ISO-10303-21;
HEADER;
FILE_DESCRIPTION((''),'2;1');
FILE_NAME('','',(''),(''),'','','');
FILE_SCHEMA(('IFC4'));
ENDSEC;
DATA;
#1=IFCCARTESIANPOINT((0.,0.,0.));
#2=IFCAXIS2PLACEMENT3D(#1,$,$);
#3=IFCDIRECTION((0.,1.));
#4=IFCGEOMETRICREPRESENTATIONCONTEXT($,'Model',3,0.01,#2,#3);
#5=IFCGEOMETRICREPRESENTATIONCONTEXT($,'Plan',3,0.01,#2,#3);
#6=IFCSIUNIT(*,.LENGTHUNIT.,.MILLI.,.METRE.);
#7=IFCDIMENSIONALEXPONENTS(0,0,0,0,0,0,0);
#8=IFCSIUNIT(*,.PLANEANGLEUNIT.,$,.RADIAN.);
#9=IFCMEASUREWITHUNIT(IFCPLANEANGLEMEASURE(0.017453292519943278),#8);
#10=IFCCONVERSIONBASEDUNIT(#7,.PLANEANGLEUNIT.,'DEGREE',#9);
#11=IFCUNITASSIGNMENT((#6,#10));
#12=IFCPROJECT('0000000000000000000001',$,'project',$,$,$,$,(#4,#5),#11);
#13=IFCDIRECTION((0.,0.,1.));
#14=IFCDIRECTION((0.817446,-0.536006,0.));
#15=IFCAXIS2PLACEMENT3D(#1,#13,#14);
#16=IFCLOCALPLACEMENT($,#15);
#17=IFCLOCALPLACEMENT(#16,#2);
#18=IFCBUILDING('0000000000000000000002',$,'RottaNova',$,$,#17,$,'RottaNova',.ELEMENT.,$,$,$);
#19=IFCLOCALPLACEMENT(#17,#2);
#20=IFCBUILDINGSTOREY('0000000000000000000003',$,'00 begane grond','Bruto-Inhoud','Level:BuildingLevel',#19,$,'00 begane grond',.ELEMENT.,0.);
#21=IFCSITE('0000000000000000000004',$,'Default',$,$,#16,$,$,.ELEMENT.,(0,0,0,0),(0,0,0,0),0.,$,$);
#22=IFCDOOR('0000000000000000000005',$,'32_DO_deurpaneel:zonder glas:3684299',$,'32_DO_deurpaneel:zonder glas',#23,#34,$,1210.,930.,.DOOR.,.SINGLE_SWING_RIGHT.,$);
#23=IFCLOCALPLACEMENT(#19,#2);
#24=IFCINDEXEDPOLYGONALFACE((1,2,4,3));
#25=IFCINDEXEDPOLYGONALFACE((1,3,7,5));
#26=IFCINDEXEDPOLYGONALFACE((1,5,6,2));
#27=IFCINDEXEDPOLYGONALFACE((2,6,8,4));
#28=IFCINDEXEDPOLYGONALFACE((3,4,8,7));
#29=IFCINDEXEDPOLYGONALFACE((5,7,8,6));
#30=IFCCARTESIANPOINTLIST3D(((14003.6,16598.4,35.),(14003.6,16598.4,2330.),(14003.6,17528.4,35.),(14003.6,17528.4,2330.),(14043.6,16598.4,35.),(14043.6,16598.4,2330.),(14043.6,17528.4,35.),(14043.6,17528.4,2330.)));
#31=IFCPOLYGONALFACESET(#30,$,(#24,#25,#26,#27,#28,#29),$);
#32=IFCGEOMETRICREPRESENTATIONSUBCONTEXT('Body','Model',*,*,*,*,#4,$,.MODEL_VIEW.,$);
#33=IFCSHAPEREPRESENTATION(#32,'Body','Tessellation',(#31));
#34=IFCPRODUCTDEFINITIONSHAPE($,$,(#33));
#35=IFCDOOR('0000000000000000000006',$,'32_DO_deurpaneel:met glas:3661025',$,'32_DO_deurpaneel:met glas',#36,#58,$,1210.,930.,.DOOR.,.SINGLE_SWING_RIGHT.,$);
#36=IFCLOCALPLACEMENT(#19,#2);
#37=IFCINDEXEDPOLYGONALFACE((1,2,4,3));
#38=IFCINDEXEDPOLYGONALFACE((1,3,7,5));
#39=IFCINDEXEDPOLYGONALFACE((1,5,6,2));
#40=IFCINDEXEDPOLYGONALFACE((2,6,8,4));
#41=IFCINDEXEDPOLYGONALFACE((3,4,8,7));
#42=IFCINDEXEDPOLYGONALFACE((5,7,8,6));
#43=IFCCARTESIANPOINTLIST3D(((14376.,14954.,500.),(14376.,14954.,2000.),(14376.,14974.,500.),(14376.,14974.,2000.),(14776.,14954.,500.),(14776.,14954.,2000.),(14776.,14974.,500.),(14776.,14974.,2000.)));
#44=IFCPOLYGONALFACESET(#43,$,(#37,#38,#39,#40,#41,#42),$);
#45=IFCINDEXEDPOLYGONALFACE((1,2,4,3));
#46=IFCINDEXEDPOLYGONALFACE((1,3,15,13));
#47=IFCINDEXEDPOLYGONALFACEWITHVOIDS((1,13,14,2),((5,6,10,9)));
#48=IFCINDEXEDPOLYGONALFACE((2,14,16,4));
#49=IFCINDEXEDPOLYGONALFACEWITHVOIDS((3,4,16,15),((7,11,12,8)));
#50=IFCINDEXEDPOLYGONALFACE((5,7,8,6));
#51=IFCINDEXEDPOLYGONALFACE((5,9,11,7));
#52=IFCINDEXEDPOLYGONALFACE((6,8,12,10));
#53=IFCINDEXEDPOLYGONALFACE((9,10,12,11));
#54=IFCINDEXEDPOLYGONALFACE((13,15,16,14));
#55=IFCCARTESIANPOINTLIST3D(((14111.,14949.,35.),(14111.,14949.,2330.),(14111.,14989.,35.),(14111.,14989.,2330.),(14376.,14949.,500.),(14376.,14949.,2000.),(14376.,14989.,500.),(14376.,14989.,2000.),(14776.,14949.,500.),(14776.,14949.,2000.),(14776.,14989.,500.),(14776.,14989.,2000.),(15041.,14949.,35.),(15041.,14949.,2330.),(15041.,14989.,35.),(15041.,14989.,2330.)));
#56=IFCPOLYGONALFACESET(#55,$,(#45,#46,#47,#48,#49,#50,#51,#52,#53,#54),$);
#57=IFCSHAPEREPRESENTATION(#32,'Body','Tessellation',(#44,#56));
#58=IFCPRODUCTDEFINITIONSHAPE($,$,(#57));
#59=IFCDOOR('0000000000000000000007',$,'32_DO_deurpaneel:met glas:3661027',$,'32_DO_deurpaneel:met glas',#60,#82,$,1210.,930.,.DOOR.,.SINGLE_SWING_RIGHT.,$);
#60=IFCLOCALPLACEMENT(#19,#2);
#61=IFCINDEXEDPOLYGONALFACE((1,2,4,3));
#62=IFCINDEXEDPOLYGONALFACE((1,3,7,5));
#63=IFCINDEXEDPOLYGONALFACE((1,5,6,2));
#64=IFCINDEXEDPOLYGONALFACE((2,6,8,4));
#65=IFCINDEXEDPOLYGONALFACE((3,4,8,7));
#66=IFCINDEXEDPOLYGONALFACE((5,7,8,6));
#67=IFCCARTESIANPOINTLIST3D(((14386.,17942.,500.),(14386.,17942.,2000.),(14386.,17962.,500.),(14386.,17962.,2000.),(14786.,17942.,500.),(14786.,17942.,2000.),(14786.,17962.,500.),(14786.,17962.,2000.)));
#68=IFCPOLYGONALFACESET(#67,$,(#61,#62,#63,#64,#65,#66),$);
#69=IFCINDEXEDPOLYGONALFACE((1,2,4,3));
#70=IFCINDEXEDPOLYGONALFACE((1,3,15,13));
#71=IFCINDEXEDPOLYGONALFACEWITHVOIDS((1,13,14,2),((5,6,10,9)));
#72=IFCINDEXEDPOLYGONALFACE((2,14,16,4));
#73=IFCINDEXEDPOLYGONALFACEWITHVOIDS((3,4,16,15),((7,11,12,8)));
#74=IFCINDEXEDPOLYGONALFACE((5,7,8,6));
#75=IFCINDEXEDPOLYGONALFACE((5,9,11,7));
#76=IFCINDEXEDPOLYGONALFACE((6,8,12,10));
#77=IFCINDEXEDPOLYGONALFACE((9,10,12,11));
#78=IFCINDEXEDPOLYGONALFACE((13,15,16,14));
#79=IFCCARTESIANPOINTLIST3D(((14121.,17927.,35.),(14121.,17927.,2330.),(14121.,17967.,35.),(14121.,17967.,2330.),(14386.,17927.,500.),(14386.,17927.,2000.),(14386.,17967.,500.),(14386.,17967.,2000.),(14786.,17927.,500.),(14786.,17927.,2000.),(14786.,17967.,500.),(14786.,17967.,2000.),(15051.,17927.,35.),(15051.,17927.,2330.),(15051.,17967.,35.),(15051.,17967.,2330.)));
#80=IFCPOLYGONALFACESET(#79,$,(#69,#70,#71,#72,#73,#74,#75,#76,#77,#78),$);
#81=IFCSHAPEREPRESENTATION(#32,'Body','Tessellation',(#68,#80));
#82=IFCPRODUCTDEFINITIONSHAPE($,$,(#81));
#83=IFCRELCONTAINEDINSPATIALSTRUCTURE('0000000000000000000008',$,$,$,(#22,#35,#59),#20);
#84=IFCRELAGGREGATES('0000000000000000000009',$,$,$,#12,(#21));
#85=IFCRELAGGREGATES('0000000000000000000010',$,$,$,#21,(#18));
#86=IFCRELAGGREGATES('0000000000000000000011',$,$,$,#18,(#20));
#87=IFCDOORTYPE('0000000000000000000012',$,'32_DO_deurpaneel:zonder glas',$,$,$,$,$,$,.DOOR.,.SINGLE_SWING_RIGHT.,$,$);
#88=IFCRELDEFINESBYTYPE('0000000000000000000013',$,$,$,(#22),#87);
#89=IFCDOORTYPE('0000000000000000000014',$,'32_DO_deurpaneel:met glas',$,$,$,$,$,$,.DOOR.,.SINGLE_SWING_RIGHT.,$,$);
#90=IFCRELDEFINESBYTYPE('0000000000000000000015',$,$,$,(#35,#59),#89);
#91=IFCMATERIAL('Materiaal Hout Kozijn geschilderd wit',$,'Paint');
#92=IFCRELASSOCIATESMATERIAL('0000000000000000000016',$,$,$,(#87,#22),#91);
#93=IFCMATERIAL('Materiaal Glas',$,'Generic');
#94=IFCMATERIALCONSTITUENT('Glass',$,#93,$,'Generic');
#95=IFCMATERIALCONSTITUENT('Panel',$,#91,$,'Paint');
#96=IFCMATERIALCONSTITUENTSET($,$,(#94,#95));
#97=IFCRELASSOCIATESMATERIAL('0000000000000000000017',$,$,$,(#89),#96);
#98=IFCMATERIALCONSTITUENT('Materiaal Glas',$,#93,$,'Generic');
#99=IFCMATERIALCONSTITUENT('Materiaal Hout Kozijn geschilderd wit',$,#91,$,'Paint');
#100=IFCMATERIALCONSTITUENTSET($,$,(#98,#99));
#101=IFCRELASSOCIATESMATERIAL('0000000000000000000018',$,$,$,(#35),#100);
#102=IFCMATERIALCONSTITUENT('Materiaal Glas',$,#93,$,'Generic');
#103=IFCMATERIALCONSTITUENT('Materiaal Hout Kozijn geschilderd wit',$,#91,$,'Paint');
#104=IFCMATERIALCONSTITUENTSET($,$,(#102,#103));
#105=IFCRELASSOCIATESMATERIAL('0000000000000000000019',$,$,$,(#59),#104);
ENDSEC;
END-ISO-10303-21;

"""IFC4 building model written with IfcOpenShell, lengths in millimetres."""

from ifc_helpers import new_model, entity, si_unit, converted_unit, direction, frame, origin, place, context, subcontext, project, spatial, indexed_curve, outline, extrude, source, transform, mapped, material, constituent, constituent_set, type_object, type_shapes, element, save


model = new_model("IFC4")

# Units and contexts
model_context = context("Model", 3, precision=0.01, world=origin(), true_north=direction((0.0, 1.0)))
plan_context = context("Plan", 3, precision=0.01, world=origin(), true_north=direction((0.0, 1.0)))
body_context = subcontext(model_context, "Body", "Model", "MODEL_VIEW")
ifc_project = project(units=[si_unit("LENGTHUNIT", "METRE", prefix="MILLI"), converted_unit("PLANEANGLEUNIT", "DEGREE", entity("IfcPlaneAngleMeasure", 0.017453292519943278), si_unit("PLANEANGLEUNIT", "RADIAN"), dimensions=[0, 0, 0, 0, 0, 0, 0])], contexts=[model_context, plan_context])

# Site, building, storey
site_placement = place(None, frame((0.0, 0.0, 0.0), z_axis=(0.0, 0.0, 1.0), x_axis=(0.817446, -0.536006, 0.0)))
site = spatial("IfcSite", under=ifc_project, at=site_placement, Name="Default", CompositionType="ELEMENT", RefLatitude=(0, 0, 0, 0), RefLongitude=(0, 0, 0, 0), RefElevation=0.0)
building_placement = place(site_placement, origin())
building = spatial("IfcBuilding", under=site, at=building_placement, Name="RottaNova", LongName="RottaNova", CompositionType="ELEMENT")
storey_placement = place(building_placement, origin())
storey = spatial("IfcBuildingStorey", under=building, at=storey_placement, Name="00 begane grond", Description="Bruto-Inhoud", ObjectType="Level:BuildingLevel", LongName="00 begane grond", CompositionType="ELEMENT", Elevation=0.0)

# Doors
ifc_material_1 = material(Name="Materiaal Hout Kozijn geschilderd wit", Category="Paint")
door_type_1 = type_object("IfcDoorType", Name="32_DO_deurpaneel:zonder glas", OperationType="SINGLE_SWING_RIGHT", PredefinedType="DOOR", material=ifc_material_1)
shared_shape_1 = source(origin(), body_context, "Body", "SweptSolid", [
    extrude(outline(indexed_curve([(-20.0, -1147.5), (20.0, -1147.5), (20.0, 1147.5), (-20.0, 1147.5), (-20.0, -1147.5)], self_intersect=False)), frame((-465.0, -20.0, 1182.5), z_axis=(1.0, 0.0, 0.0), x_axis=(0.0, 1.0, 0.0)), (0.0, 0.0, 1.0), 930.0),
])
type_shapes(door_type_1, [shared_shape_1])
door_1_placement = place(storey_placement, frame((14003.6, 17063.4, 0.0), z_axis=(0.0, 0.0, 1.0), x_axis=(0.0, 1.0, 0.0)))
element("IfcDoor", 1, at=door_1_placement, inside=storey, type_object=door_type_1, material=ifc_material_1, Name="32_DO_deurpaneel:zonder glas:3684299", ObjectType="32_DO_deurpaneel:zonder glas", OperationType="SINGLE_SWING_RIGHT", OverallHeight=1210.0, OverallWidth=930.0, PredefinedType="DOOR", context=body_context, shape_type="MappedRepresentation", body=[
    mapped(shared_shape_1, transform((0.0, 0.0, 0.0), scale=1.0)),
])
ifc_material_2 = material(Name="Materiaal Glas", Category="Generic")
ifc_constituent_1 = constituent(ifc_material_2, Name="Materiaal Glas", Category="Generic")
ifc_constituent_2 = constituent(ifc_material_1, Name="Materiaal Hout Kozijn geschilderd wit", Category="Paint")
ifc_constituent_set_1 = constituent_set(constituents=[ifc_constituent_1, ifc_constituent_2])
ifc_constituent_3 = constituent(ifc_material_2, Name="Glass", Category="Generic")
ifc_constituent_4 = constituent(ifc_material_1, Name="Panel", Category="Paint")
ifc_constituent_set_2 = constituent_set(constituents=[ifc_constituent_3, ifc_constituent_4])
door_type_2 = type_object("IfcDoorType", Name="32_DO_deurpaneel:met glas", OperationType="SINGLE_SWING_RIGHT", PredefinedType="DOOR", material=ifc_constituent_set_2)
shared_shape_2 = source(origin(), body_context, "Body", "SweptSolid", [
    extrude(outline(indexed_curve([(-10.0, -200.0), (10.0, -200.0), (10.0, 200.0), (-10.0, 200.0), (-10.0, -200.0)], self_intersect=False)), frame((0.0, 25.0, 500.0), z_axis=(0.0, 0.0, 1.0), x_axis=(0.0, 1.0, 0.0)), (0.0, 0.0, 1.0), 1500.0),
    extrude(outline(indexed_curve([(-1147.5, -465.0), (1147.5, -465.0), (1147.5, 465.0), (-1147.5, 465.0), (-1147.5, -465.0)], self_intersect=False), holes=[indexed_curve([(817.5, -200.0), (-682.5, -200.0), (-682.5, 200.0), (817.5, 200.0), (817.5, -200.0)], self_intersect=False)]), frame((0.0, 0.0, 1182.5), z_axis=(0.0, 1.0, 0.0), x_axis=(0.0, 0.0, 1.0)), (0.0, 0.0, 1.0), 40.0),
])
type_shapes(door_type_2, [shared_shape_2])
door_2_placement = place(storey_placement, frame((14576.0, 14989.0, 0.0), z_axis=(0.0, 0.0, 1.0), x_axis=(-1.0, 0.0, 0.0)))
element("IfcDoor", 2, at=door_2_placement, inside=storey, type_object=door_type_2, material=ifc_constituent_set_1, Name="32_DO_deurpaneel:met glas:3661025", ObjectType="32_DO_deurpaneel:met glas", OperationType="SINGLE_SWING_RIGHT", OverallHeight=1210.0, OverallWidth=930.0, PredefinedType="DOOR", context=body_context, shape_type="MappedRepresentation", body=[
    mapped(shared_shape_2, transform((0.0, 0.0, 0.0), scale=1.0)),
])
ifc_constituent_5 = constituent(ifc_material_2, Name="Materiaal Glas", Category="Generic")
ifc_constituent_6 = constituent(ifc_material_1, Name="Materiaal Hout Kozijn geschilderd wit", Category="Paint")
ifc_constituent_set_3 = constituent_set(constituents=[ifc_constituent_5, ifc_constituent_6])
door_3_placement = place(storey_placement, frame((14586.0, 17927.0, 0.0)))
element("IfcDoor", 3, at=door_3_placement, inside=storey, type_object=door_type_2, material=ifc_constituent_set_3, Name="32_DO_deurpaneel:met glas:3661027", ObjectType="32_DO_deurpaneel:met glas", OperationType="SINGLE_SWING_RIGHT", OverallHeight=1210.0, OverallWidth=930.0, PredefinedType="DOOR", context=body_context, shape_type="MappedRepresentation", body=[
    mapped(shared_shape_2, transform((0.0, 0.0, 0.0), scale=1.0)),
])

save(model, "model.ifc")
